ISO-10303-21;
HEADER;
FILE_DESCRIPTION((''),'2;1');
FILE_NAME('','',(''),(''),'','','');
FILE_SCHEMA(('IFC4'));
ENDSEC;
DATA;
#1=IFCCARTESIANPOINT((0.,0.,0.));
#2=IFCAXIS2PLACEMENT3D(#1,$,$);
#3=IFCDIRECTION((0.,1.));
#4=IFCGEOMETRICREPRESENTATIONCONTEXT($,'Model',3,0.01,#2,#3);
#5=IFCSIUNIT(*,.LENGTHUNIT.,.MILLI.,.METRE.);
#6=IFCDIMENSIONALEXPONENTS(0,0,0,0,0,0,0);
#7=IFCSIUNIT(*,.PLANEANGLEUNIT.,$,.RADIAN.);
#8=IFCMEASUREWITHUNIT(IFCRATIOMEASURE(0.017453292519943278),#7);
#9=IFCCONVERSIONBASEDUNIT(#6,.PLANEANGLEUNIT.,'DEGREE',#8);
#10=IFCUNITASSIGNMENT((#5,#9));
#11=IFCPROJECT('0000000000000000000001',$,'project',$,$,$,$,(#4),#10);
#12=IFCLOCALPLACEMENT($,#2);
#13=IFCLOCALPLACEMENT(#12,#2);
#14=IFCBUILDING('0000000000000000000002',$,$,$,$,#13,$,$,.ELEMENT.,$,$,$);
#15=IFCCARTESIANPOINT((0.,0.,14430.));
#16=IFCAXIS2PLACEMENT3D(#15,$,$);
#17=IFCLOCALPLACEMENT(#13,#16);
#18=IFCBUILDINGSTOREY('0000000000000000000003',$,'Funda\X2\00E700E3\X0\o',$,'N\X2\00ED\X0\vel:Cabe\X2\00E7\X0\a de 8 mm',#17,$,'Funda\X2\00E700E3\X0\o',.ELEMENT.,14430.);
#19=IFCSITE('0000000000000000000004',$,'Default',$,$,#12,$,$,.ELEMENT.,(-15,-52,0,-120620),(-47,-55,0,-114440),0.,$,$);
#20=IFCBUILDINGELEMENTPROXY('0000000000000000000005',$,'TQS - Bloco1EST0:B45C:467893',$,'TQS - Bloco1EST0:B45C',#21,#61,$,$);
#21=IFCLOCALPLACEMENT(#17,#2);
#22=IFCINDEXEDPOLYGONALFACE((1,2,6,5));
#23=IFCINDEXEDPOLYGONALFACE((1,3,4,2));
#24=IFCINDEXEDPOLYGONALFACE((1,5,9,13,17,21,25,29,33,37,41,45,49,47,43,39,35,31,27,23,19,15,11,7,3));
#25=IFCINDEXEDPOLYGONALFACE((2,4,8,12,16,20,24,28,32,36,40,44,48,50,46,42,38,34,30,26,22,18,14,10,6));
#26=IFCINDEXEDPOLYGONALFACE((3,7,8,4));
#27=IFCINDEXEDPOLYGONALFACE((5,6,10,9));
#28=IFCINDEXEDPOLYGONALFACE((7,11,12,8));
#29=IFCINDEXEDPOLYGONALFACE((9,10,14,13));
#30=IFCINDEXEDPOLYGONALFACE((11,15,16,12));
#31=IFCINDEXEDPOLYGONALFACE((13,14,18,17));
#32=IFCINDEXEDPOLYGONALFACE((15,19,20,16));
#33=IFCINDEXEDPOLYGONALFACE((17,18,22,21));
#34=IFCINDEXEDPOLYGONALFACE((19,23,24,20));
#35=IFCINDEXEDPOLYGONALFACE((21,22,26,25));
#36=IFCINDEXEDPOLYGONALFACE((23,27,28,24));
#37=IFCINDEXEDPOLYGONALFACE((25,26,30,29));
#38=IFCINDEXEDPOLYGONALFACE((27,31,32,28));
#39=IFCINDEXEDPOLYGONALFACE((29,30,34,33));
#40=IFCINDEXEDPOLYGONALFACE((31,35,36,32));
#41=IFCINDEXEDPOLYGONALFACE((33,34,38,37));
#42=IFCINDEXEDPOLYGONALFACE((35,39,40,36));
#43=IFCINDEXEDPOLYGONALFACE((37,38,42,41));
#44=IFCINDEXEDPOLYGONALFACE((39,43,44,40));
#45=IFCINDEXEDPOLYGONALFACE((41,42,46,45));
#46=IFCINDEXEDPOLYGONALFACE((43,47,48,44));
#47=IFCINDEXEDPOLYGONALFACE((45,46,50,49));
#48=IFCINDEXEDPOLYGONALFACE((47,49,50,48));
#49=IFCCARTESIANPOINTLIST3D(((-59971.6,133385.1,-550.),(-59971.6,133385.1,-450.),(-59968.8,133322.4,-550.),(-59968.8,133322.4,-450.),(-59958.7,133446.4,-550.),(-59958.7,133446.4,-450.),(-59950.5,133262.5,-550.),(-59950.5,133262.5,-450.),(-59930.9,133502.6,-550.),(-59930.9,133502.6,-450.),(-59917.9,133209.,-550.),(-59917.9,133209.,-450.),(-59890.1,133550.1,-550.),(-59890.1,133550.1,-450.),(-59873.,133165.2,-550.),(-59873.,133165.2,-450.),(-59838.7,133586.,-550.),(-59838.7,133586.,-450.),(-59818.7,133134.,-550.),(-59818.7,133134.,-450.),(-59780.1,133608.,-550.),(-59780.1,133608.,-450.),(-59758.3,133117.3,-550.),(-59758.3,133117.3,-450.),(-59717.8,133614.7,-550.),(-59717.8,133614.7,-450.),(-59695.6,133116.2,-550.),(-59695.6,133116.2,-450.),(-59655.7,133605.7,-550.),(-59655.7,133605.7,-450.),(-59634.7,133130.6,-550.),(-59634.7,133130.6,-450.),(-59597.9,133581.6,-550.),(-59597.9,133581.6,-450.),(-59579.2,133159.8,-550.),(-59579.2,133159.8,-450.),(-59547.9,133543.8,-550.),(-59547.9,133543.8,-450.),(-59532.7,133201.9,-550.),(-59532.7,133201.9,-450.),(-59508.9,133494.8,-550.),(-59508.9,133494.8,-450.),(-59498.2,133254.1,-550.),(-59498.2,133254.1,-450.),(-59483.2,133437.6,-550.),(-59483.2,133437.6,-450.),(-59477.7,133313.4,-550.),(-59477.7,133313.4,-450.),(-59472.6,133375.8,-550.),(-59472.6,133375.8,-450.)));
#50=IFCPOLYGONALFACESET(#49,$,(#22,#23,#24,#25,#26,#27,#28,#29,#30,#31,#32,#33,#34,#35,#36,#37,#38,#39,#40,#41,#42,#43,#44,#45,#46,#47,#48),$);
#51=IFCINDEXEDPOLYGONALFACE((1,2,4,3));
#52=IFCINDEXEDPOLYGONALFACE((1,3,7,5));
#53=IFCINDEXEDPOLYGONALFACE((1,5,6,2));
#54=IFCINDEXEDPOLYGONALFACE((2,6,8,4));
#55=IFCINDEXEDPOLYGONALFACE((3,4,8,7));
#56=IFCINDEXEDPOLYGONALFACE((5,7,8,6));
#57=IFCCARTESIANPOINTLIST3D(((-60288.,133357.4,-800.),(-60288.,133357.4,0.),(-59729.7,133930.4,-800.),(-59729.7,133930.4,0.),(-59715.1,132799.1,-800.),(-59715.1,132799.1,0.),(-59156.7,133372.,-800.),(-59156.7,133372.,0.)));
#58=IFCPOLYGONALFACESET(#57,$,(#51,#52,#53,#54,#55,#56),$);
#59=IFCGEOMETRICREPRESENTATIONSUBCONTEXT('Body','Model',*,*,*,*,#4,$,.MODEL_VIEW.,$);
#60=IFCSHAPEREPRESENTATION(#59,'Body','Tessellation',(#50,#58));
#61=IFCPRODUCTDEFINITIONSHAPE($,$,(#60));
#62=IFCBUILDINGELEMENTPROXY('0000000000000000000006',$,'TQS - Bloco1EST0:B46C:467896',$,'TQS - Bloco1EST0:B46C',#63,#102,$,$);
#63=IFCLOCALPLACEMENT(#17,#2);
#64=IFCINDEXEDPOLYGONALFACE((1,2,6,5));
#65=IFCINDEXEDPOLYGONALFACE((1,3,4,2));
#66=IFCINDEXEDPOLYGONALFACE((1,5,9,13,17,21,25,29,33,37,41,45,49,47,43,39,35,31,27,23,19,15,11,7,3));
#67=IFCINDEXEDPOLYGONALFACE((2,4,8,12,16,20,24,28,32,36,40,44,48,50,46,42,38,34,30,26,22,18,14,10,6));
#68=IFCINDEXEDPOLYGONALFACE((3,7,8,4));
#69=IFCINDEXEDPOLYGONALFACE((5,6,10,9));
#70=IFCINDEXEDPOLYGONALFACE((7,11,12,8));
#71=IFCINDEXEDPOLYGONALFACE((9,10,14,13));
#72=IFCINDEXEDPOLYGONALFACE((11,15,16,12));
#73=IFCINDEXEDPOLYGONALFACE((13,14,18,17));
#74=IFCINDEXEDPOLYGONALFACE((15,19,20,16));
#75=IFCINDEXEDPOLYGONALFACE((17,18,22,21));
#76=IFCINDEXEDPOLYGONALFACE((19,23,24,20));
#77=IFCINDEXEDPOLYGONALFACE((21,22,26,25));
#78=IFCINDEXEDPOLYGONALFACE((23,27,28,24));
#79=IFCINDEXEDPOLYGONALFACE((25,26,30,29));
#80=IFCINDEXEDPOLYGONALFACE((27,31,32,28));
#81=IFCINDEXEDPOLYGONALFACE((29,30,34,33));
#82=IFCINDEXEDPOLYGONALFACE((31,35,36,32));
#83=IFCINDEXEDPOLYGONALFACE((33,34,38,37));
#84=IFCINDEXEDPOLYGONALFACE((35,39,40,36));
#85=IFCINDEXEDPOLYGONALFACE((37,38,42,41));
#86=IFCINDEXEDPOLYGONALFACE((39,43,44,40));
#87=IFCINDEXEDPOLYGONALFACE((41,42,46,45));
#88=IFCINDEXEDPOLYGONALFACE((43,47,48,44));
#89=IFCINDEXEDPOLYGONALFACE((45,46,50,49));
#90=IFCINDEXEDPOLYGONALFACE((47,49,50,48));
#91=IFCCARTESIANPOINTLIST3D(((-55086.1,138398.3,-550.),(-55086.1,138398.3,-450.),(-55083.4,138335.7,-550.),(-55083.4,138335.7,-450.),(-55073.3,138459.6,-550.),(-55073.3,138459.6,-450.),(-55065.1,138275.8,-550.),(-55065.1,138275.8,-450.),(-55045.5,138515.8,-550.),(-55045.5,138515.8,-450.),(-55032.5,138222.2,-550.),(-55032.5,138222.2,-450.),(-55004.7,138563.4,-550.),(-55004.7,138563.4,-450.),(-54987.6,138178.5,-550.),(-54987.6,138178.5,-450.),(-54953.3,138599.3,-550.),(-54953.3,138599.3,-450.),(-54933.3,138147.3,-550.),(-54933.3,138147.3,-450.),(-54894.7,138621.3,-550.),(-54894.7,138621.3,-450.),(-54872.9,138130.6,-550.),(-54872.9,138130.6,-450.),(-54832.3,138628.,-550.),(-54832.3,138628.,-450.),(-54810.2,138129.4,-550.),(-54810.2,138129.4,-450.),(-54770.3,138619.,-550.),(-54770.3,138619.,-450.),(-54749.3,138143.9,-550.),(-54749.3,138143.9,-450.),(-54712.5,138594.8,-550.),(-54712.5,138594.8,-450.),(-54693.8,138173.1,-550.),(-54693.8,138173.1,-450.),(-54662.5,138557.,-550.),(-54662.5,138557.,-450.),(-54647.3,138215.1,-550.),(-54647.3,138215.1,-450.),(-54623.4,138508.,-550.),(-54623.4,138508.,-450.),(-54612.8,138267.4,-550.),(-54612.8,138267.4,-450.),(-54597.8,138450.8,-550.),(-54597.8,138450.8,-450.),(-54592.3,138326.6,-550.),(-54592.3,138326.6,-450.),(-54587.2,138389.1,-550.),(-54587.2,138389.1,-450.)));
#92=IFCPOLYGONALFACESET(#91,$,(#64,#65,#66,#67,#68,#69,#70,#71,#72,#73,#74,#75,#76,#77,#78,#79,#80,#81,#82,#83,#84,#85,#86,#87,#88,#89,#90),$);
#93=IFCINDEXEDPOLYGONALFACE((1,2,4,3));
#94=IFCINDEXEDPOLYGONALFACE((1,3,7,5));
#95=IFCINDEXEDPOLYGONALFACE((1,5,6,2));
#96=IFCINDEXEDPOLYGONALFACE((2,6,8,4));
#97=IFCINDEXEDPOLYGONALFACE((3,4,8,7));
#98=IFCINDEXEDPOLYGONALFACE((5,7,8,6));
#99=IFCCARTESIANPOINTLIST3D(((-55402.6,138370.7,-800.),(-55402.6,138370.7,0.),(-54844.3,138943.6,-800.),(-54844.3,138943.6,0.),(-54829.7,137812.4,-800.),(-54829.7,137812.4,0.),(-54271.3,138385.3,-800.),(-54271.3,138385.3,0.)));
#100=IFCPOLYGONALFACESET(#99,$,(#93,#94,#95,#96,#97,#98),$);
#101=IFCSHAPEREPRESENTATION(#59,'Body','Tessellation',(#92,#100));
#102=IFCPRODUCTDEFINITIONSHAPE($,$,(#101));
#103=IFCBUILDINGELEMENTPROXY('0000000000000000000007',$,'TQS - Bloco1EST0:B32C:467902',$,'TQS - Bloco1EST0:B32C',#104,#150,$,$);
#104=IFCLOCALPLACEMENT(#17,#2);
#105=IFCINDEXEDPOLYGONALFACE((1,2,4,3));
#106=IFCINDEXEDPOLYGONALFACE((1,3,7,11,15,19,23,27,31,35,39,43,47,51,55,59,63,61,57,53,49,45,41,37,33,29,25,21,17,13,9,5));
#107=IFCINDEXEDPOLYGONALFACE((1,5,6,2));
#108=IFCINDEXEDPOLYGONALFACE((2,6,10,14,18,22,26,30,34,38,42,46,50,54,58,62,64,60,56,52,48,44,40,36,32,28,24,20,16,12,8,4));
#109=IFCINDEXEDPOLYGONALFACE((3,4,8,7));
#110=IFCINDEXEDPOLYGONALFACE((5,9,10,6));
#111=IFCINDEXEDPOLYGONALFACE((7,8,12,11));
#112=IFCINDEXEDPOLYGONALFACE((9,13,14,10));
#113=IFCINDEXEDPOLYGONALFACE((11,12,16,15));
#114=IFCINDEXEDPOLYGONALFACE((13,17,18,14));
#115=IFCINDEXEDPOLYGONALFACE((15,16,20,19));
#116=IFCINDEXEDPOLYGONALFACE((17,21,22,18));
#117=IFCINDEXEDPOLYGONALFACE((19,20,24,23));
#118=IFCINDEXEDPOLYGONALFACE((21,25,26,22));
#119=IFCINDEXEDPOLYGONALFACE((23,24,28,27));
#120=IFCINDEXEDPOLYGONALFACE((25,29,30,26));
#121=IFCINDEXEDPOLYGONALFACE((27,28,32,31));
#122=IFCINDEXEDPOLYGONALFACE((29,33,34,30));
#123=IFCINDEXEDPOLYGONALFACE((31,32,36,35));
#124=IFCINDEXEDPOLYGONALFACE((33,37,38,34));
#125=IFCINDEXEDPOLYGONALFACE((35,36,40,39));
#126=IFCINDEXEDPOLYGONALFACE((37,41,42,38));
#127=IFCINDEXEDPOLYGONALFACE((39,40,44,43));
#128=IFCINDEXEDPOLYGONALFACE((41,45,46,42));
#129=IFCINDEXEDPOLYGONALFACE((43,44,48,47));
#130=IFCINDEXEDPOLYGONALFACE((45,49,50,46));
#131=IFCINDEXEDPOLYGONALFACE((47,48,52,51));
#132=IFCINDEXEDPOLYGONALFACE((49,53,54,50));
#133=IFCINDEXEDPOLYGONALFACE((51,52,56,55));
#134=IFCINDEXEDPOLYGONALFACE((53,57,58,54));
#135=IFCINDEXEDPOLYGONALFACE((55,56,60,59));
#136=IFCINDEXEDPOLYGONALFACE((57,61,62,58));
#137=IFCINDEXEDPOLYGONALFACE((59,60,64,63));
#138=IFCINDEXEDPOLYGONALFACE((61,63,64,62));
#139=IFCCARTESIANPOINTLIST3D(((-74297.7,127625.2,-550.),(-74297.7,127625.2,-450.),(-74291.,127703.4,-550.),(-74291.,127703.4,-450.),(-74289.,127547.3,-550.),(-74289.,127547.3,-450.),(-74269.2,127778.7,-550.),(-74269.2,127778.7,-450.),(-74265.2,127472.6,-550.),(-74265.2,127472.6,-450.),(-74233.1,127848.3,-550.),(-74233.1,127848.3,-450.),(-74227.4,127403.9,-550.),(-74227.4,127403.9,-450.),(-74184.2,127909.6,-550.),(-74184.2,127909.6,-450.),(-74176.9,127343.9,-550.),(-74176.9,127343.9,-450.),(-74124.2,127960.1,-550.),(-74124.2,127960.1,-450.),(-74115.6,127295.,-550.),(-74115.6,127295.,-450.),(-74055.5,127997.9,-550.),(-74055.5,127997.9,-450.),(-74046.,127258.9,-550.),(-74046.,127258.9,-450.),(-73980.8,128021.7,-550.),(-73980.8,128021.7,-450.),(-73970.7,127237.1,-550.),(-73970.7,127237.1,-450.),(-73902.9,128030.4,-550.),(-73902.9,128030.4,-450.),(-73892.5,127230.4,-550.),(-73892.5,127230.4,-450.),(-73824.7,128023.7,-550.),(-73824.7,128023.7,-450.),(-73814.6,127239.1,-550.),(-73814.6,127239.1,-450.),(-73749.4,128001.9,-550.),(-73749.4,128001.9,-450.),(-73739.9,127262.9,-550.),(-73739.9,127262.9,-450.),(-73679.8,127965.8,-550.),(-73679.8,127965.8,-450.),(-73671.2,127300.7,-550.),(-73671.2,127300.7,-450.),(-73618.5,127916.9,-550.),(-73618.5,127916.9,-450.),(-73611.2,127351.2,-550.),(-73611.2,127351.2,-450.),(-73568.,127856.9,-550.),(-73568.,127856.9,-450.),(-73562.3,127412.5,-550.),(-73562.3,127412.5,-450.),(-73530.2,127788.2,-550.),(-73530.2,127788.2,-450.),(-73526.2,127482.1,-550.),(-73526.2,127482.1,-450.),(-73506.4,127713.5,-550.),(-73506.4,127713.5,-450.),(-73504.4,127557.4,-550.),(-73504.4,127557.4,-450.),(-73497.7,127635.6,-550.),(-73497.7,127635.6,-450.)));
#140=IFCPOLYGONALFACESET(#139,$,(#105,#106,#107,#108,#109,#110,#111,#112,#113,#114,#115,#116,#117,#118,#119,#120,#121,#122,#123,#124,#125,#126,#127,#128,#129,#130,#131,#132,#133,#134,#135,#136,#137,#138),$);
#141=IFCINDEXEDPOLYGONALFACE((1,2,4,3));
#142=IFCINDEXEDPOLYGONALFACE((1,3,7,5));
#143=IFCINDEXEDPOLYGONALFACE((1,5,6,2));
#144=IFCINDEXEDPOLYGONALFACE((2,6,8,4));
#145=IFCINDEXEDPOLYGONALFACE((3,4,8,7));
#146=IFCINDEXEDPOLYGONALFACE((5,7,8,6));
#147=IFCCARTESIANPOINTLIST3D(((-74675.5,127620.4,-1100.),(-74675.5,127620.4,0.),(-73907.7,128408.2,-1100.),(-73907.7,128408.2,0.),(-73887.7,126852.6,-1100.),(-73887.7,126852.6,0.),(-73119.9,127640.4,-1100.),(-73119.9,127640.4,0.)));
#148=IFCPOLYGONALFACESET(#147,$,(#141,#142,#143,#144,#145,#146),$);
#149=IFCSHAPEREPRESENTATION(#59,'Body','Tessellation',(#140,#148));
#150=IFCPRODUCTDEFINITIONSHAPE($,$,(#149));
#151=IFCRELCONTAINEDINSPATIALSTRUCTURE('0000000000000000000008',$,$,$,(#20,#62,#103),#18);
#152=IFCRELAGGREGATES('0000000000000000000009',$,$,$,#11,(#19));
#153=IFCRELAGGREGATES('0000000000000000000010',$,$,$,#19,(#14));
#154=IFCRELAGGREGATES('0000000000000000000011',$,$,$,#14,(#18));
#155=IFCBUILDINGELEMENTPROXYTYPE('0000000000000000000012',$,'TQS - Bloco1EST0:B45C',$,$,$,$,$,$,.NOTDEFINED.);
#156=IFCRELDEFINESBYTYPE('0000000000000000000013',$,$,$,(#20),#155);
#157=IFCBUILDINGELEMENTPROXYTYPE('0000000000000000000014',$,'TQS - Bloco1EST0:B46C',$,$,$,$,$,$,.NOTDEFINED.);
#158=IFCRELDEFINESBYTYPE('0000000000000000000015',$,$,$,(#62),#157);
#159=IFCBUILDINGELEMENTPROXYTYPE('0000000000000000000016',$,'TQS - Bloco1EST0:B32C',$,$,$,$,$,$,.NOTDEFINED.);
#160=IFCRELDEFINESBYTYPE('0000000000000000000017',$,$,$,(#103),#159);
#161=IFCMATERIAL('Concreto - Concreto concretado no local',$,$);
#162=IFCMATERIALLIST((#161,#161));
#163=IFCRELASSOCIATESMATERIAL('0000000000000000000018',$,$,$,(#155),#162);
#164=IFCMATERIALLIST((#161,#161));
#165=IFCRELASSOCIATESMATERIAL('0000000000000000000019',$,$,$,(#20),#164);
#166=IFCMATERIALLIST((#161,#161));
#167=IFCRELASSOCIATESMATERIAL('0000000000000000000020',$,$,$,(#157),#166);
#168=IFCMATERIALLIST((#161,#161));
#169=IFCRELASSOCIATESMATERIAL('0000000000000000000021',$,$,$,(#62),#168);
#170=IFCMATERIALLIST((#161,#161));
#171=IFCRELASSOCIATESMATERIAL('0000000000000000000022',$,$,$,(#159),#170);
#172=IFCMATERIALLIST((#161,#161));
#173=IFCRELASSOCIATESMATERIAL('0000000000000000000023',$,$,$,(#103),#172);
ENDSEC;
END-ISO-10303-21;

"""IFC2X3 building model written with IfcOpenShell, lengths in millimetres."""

from ifc_helpers import new_model, entity, si_unit, converted_unit, direction, frame, frame_2d, origin, origin_2d_with_axis, place, context, subcontext, project, spatial, rectangle, circle, extrude, source, transform, mapped, material, material_list, type_object, type_shapes, element, save


model = new_model("IFC2X3")

# Units and contexts
model_context = context("Model", 3, precision=0.01, world=origin(), true_north=direction((0.0, 1.0)))
body_context = subcontext(model_context, "Body", "Model", "MODEL_VIEW")
ifc_project = project(units=[si_unit("LENGTHUNIT", "METRE", prefix="MILLI"), converted_unit("PLANEANGLEUNIT", "DEGREE", entity("IfcRatioMeasure", 0.017453292519943278), si_unit("PLANEANGLEUNIT", "RADIAN"), dimensions=[0, 0, 0, 0, 0, 0, 0])], contexts=[model_context])

# Site, building, storey
site_placement = place(None, origin())
site = spatial("IfcSite", under=ifc_project, at=site_placement, Name="Default", CompositionType="ELEMENT", RefLatitude=(-15, -52, 0, -120620), RefLongitude=(-47, -55, 0, -114440), RefElevation=0.0)
building_placement = place(site_placement, origin())
building = spatial("IfcBuilding", under=site, at=building_placement, CompositionType="ELEMENT")
storey_placement = place(building_placement, frame((0.0, 0.0, 14430.0)))
storey = spatial("IfcBuildingStorey", under=building, at=storey_placement, Name="Fundação", ObjectType="Nível:Cabeça de 8 mm", LongName="Fundação", CompositionType="ELEMENT", Elevation=14430.0)

# Building element proxies
ifc_material_1 = material(Name="Concreto - Concreto concretado no local")
ifc_material_list_1 = material_list([ifc_material_1, ifc_material_1])
ifc_material_list_2 = material_list([ifc_material_1, ifc_material_1])
building_element_proxy_type_1 = type_object("IfcBuildingElementProxyType", Name="TQS - Bloco1EST0:B45C", PredefinedType="NOTDEFINED", material=ifc_material_list_2)
shared_shape_1 = source(origin(), body_context, "Body", "SweptSolid", [
    extrude(circle(Radius=250.0, at=frame_2d((0.0, 0.0), x_axis=(1.0, 0.0))), frame((0.0, 0.0, -550.0)), (0.0, 0.0, 1.0), 100.0),
    extrude(rectangle(XDim=800.0, YDim=800.0, at=origin_2d_with_axis()), frame((0.0, 0.0, -800.0), z_axis=(0.0, 0.0, 1.0), x_axis=(-1.0, 0.0, 0.0)), (0.0, 0.0, 1.0), 800.0),
])
type_shapes(building_element_proxy_type_1, [shared_shape_1])
proxy_1_placement = place(storey_placement, frame((-59722.4, 133364.7, 0.0), z_axis=(0.0, 0.0, 1.0), x_axis=(0.697915, 0.71618, 0.0)))
element("IfcBuildingElementProxy", 1, at=proxy_1_placement, inside=storey, type_object=building_element_proxy_type_1, material=ifc_material_list_1, Name="TQS - Bloco1EST0:B45C:467893", ObjectType="TQS - Bloco1EST0:B45C", context=body_context, shape_type="MappedRepresentation", body=[
    mapped(shared_shape_1, transform((0.0, 0.0, 0.0), scale=1.0)),
])
ifc_material_list_3 = material_list([ifc_material_1, ifc_material_1])
ifc_material_list_4 = material_list([ifc_material_1, ifc_material_1])
building_element_proxy_type_2 = type_object("IfcBuildingElementProxyType", Name="TQS - Bloco1EST0:B46C", PredefinedType="NOTDEFINED", material=ifc_material_list_4)
shared_shape_2 = source(origin(), body_context, "Body", "SweptSolid", [
    extrude(circle(Radius=250.0, at=frame_2d((0.0, 0.0), x_axis=(1.0, 0.0))), frame((0.0, 0.0, -550.0)), (0.0, 0.0, 1.0), 100.0),
    extrude(rectangle(XDim=800.0, YDim=800.0, at=origin_2d_with_axis()), frame((0.0, 0.0, -800.0), z_axis=(0.0, 0.0, 1.0), x_axis=(-1.0, 0.0, 0.0)), (0.0, 0.0, 1.0), 800.0),
])
type_shapes(building_element_proxy_type_2, [shared_shape_2])
proxy_2_placement = place(storey_placement, frame((-54837.0, 138378.0, 0.0), z_axis=(0.0, 0.0, 1.0), x_axis=(0.697915, 0.71618, 0.0)))
element("IfcBuildingElementProxy", 2, at=proxy_2_placement, inside=storey, type_object=building_element_proxy_type_2, material=ifc_material_list_3, Name="TQS - Bloco1EST0:B46C:467896", ObjectType="TQS - Bloco1EST0:B46C", context=body_context, shape_type="MappedRepresentation", body=[
    mapped(shared_shape_2, transform((0.0, 0.0, 0.0), scale=1.0)),
])
ifc_material_list_5 = material_list([ifc_material_1, ifc_material_1])
ifc_material_list_6 = material_list([ifc_material_1, ifc_material_1])
building_element_proxy_type_3 = type_object("IfcBuildingElementProxyType", Name="TQS - Bloco1EST0:B32C", PredefinedType="NOTDEFINED", material=ifc_material_list_6)
shared_shape_3 = source(origin(), body_context, "Body", "SweptSolid", [
    extrude(circle(Radius=400.0, at=frame_2d((0.0, 0.0), x_axis=(1.0, 0.0))), frame((0.0, 0.0, -550.0)), (0.0, 0.0, 1.0), 100.0),
    extrude(rectangle(XDim=1100.0, YDim=1100.0, at=origin_2d_with_axis()), frame((0.0, 0.0, -1100.0), z_axis=(0.0, 0.0, 1.0), x_axis=(-1.0, 0.0, 0.0)), (0.0, 0.0, 1.0), 1100.0),
])
type_shapes(building_element_proxy_type_3, [shared_shape_3])
proxy_3_placement = place(storey_placement, frame((-73897.7, 127630.4, 0.0), z_axis=(0.0, 0.0, 1.0), x_axis=(0.697915, 0.71618, 0.0)))
element("IfcBuildingElementProxy", 3, at=proxy_3_placement, inside=storey, type_object=building_element_proxy_type_3, material=ifc_material_list_5, Name="TQS - Bloco1EST0:B32C:467902", ObjectType="TQS - Bloco1EST0:B32C", context=body_context, shape_type="MappedRepresentation", body=[
    mapped(shared_shape_3, transform((0.0, 0.0, 0.0), scale=1.0)),
])

save(model, "model.ifc")
